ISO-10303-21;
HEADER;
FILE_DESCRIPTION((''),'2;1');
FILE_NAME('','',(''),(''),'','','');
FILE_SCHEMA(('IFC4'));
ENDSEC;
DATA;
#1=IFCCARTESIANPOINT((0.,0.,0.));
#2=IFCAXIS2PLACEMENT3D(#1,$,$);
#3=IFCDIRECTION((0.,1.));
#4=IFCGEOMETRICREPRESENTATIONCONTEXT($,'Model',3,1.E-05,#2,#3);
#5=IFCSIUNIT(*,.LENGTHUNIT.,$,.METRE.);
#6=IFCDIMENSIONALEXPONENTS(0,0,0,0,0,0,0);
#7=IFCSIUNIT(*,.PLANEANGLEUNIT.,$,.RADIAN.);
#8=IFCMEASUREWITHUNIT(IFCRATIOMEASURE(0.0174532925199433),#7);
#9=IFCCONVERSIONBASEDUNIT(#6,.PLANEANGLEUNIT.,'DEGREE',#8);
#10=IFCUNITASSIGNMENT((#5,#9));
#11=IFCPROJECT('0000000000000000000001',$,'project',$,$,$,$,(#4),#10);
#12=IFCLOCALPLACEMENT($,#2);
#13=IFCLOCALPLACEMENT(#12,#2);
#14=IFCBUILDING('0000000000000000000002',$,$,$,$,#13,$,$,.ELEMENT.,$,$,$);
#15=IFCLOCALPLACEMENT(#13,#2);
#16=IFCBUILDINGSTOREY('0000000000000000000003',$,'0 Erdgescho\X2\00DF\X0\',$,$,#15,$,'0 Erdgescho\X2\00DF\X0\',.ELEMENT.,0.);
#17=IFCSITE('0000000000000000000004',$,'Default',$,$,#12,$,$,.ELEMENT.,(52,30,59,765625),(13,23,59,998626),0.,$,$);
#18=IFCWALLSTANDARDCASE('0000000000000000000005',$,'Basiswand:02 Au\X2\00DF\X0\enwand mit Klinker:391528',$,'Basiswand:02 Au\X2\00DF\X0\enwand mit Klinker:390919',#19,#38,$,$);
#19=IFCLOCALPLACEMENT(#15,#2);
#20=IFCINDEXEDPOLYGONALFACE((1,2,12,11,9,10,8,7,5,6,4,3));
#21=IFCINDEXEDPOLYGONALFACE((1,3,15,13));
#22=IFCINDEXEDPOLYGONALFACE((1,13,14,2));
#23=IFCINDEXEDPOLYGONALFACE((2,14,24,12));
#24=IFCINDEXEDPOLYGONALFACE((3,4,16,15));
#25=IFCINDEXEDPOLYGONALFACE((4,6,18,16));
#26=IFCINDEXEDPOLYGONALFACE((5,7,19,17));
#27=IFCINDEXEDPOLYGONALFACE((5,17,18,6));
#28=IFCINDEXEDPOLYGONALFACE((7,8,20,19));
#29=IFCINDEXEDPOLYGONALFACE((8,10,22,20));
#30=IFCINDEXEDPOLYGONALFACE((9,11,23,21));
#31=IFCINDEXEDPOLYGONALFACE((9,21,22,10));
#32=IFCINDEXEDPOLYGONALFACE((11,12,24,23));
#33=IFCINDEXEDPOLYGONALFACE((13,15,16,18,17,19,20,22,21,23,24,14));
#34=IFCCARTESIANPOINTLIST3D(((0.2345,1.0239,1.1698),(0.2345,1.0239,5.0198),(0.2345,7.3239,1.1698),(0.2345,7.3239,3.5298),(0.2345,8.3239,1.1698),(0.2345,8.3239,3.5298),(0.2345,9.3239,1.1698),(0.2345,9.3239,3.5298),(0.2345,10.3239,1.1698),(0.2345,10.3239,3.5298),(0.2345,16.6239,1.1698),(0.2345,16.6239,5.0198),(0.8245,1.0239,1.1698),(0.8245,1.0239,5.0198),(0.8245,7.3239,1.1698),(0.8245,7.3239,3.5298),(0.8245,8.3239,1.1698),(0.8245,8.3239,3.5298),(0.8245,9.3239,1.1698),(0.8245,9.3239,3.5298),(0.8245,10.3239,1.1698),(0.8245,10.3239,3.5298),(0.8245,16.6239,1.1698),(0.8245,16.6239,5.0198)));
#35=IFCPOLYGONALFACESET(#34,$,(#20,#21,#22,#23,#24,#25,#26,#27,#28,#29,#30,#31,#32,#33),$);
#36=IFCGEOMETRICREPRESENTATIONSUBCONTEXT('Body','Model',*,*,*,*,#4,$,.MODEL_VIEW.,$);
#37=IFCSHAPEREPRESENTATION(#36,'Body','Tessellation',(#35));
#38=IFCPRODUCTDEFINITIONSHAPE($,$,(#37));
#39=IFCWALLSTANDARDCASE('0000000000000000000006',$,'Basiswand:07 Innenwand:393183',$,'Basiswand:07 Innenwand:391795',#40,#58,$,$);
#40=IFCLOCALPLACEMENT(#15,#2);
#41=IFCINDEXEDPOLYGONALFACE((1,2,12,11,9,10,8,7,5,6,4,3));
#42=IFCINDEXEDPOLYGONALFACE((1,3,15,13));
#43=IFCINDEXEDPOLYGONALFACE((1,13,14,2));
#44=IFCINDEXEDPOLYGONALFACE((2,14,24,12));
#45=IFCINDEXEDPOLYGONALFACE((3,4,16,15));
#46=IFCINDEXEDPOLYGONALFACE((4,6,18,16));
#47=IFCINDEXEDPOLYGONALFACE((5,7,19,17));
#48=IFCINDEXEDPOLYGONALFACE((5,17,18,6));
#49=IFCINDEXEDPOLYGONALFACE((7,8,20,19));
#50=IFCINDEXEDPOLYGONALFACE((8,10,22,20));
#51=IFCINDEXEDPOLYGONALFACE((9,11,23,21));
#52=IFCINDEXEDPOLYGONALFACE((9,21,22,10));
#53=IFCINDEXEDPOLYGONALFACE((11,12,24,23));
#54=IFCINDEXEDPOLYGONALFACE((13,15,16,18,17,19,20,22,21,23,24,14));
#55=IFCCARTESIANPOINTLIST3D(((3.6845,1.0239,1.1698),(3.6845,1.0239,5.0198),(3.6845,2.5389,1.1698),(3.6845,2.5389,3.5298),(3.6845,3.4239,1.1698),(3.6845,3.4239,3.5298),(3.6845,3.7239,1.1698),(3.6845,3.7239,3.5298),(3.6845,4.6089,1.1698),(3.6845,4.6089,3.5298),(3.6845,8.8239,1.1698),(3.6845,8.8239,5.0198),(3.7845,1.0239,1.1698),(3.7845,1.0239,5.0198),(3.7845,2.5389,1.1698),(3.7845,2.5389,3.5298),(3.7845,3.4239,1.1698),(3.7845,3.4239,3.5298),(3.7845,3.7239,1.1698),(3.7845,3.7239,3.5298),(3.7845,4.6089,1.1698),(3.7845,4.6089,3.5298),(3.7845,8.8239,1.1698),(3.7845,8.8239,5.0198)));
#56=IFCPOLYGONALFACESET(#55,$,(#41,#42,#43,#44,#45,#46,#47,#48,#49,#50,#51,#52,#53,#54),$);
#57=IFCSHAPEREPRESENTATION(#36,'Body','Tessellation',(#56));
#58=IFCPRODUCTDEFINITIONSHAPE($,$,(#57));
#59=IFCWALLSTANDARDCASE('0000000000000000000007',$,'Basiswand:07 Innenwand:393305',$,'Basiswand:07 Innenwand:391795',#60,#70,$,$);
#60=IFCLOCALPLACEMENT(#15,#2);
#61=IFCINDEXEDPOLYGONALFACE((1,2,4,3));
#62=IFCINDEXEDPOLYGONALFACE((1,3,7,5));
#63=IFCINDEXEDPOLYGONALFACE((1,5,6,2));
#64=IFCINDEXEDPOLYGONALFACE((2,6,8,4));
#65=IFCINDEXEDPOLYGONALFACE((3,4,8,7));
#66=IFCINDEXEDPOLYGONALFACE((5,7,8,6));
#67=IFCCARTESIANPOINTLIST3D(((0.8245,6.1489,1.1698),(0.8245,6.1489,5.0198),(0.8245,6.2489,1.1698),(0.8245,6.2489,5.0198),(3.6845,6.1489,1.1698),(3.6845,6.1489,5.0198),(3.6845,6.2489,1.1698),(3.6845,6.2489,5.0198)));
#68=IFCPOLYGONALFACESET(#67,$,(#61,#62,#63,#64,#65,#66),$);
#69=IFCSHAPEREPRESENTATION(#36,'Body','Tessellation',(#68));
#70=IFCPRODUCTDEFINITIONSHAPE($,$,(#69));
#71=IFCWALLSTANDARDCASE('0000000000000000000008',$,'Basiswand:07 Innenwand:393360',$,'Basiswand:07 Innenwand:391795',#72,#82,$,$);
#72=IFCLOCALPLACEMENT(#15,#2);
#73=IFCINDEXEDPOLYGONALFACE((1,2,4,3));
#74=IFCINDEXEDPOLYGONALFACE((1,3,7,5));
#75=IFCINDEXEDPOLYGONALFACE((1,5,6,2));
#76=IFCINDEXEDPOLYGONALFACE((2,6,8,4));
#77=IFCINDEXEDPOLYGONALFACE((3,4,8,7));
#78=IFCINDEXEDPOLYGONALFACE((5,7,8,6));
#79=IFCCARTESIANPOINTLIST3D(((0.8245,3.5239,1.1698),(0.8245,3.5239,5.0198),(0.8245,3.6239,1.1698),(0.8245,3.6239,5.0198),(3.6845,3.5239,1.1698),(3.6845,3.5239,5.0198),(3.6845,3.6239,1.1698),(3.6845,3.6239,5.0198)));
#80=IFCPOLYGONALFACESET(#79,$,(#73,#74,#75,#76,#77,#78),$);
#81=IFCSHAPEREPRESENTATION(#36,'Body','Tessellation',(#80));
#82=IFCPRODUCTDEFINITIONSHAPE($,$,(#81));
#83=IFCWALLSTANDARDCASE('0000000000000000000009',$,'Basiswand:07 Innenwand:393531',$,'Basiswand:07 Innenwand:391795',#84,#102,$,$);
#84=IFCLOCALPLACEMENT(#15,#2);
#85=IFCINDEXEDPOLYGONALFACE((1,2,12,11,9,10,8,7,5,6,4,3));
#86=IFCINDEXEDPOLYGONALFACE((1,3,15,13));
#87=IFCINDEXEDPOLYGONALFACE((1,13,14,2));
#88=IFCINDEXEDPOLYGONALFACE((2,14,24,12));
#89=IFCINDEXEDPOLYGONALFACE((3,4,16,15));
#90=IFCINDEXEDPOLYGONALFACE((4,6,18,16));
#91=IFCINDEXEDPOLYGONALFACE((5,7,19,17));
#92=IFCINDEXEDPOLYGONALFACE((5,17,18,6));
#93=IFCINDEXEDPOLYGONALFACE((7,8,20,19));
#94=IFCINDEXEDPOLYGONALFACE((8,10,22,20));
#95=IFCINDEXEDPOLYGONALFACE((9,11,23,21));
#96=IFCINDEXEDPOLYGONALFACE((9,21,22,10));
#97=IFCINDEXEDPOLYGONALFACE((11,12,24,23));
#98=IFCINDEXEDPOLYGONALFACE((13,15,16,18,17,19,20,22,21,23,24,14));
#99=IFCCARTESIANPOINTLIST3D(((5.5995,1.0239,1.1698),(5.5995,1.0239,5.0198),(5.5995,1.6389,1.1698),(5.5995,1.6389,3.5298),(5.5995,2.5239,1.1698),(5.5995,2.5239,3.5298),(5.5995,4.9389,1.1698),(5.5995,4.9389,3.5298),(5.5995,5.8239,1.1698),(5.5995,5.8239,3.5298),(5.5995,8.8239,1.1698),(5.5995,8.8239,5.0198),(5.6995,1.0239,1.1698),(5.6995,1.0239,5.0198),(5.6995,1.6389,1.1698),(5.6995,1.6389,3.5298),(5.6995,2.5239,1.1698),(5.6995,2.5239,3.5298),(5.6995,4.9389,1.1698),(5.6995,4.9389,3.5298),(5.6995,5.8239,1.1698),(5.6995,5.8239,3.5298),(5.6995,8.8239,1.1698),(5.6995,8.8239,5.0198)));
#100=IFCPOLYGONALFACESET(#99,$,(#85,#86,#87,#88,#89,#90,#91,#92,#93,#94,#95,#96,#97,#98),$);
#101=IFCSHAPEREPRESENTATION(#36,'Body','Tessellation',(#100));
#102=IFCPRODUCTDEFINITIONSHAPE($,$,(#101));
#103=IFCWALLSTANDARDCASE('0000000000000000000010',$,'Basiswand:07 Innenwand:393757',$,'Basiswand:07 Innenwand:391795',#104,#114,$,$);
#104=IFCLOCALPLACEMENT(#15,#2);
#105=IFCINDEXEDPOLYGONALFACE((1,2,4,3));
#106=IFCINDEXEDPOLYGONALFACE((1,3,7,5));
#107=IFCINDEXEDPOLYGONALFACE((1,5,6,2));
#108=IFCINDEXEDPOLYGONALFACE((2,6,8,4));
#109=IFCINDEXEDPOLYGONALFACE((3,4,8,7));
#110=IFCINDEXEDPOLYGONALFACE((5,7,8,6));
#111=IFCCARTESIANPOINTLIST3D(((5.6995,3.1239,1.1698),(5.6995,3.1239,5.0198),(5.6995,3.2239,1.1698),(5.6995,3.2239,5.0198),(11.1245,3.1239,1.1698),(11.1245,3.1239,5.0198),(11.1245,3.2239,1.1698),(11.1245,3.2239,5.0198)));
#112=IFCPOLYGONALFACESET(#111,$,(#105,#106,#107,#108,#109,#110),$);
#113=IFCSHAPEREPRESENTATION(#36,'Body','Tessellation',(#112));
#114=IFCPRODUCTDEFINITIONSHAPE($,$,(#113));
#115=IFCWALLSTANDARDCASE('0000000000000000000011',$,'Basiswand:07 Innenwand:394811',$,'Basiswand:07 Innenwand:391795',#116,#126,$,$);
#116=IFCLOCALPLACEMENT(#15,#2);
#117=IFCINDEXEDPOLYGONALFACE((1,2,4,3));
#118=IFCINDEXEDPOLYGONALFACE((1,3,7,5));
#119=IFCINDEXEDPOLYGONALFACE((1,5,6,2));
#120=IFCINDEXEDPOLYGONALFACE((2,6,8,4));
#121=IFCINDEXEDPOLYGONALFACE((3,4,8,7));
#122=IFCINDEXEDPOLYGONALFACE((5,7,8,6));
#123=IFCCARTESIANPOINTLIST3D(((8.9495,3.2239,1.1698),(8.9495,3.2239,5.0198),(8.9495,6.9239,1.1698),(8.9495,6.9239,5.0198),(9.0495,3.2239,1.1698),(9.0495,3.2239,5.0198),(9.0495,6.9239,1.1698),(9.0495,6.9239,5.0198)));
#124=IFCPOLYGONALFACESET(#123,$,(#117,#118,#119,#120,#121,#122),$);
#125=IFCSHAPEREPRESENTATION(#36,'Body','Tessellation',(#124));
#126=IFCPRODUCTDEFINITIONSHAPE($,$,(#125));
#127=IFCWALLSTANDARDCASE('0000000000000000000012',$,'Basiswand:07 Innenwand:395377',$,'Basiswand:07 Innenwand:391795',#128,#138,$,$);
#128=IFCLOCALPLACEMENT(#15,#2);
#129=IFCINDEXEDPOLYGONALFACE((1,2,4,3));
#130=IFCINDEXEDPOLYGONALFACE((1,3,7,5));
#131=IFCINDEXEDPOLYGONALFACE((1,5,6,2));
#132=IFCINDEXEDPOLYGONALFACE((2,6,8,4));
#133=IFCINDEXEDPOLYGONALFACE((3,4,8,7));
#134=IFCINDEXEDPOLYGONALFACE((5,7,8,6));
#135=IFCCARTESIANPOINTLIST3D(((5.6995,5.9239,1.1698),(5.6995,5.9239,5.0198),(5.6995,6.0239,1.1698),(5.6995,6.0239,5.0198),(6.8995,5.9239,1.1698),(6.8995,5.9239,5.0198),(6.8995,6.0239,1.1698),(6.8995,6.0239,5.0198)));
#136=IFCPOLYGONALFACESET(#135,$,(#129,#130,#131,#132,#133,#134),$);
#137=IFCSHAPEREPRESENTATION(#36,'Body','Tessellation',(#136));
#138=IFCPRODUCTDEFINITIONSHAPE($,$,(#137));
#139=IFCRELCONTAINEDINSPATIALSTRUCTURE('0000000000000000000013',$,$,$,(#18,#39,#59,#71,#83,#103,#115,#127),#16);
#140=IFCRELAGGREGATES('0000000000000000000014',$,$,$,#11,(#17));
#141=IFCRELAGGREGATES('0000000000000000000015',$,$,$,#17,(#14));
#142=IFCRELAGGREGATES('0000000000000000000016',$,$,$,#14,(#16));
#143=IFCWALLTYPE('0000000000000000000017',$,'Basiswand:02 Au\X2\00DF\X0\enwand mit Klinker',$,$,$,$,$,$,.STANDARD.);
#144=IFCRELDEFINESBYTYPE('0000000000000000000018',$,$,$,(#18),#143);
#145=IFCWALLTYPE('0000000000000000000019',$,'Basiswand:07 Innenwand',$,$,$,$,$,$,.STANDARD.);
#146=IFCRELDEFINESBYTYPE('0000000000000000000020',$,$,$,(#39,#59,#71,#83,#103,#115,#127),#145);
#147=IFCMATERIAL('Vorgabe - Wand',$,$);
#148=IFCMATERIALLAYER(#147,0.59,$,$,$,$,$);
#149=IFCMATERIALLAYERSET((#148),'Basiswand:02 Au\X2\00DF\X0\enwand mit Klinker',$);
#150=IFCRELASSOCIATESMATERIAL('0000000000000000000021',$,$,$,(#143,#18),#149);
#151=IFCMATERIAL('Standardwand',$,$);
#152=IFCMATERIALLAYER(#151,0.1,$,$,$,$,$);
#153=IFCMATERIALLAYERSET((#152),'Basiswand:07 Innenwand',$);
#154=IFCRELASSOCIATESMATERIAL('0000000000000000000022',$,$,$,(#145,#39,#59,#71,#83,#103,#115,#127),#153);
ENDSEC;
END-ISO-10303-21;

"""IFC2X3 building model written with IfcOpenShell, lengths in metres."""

from ifc_helpers import new_model, entity, si_unit, converted_unit, direction, frame, frame_2d, origin, place, context, subcontext, project, spatial, polyline, rectangle, extrude, clip, bounded_halfspace, material, layer, layer_set, layer_usage, type_object, element, save


model = new_model("IFC2X3")

# Units and contexts
model_context = context("Model", 3, precision=1e-05, world=origin(), true_north=direction((0.0, 1.0)))
body_context = subcontext(model_context, "Body", "Model", "MODEL_VIEW")
ifc_project = project(units=[si_unit("LENGTHUNIT", "METRE"), converted_unit("PLANEANGLEUNIT", "DEGREE", entity("IfcRatioMeasure", 0.0174532925199433), si_unit("PLANEANGLEUNIT", "RADIAN"), dimensions=[0, 0, 0, 0, 0, 0, 0])], contexts=[model_context])

# Site, building, storey
site_placement = place(None, origin())
site = spatial("IfcSite", under=ifc_project, at=site_placement, Name="Default", CompositionType="ELEMENT", RefLatitude=(52, 30, 59, 765625), RefLongitude=(13, 23, 59, 998626), RefElevation=0.0)
building_placement = place(site_placement, origin())
building = spatial("IfcBuilding", under=site, at=building_placement, CompositionType="ELEMENT")
storey_placement = place(building_placement, origin())
storey = spatial("IfcBuildingStorey", under=building, at=storey_placement, Name="0 Erdgeschoß", LongName="0 Erdgeschoß", CompositionType="ELEMENT", Elevation=0.0)

# Walls, openings
ifc_material_1 = material(Name="Vorgabe - Wand")
ifc_layer_1 = layer(ifc_material_1, 0.59)
ifc_layer_set_1 = layer_set([ifc_layer_1], Name="Basiswand:02 Außenwand mit Klinker")
ifc_layer_usage_1 = layer_usage(ifc_layer_set_1, "AXIS2", "NEGATIVE", 0.295)
wall_type_1 = type_object("IfcWallType", Name="Basiswand:02 Außenwand mit Klinker", PredefinedType="STANDARD", material=ifc_layer_set_1)
wall_1_placement = place(storey_placement, frame((0.5295, 1.0239, 1.1698), z_axis=(0.0, 0.0, 1.0), x_axis=(0.0, 1.0, 0.0)))
wall_1 = element("IfcWallStandardCase", 1, at=wall_1_placement, inside=storey, type_object=wall_type_1, material=ifc_layer_usage_1, Name="Basiswand:02 Außenwand mit Klinker:391528", ObjectType="Basiswand:02 Außenwand mit Klinker:390919", context=body_context, shape_type="Clipping", body=[
    clip(extrude(rectangle(XDim=15.6, YDim=0.59, at=frame_2d((7.8, 0.0), x_axis=(-1.0, 0.0))), origin(), (0.0, 0.0, 1.0), 3.85), bounded_halfspace(frame((0.0, -0.295, 3.85), z_axis=(0.0, 0.0, -1.0), x_axis=(-1.0, 0.0, 0.0)), True, frame((0.0, -0.295, 3.85)), polyline([(0.0, 0.0), (2.5, 0.0), (2.6, 0.0), (5.125, 0.0), (5.225, 0.0), (7.8, 0.0), (7.9, 0.0), (11.9, 0.0), (12.0, 0.0), (13.75, 0.0), (13.85, 0.0), (15.6, 0.0), (15.6, 0.59), (0.0, 0.59), (0.0, 0.0)]))),
])
opening_1_placement = place(wall_1_placement, frame((8.3, -0.295, 0.0)))
element("IfcOpeningElement", 2, at=opening_1_placement, cuts=wall_1, ObjectType="Opening", context=body_context, shape_type="SweptSolid", body=[
    extrude(rectangle(XDim=2.36, YDim=1.0, at=frame_2d((1.18, 0.5), x_axis=(1.0, 0.0))), frame((0.0, 0.0, 0.0), z_axis=(0.0, 1.0, 0.0), x_axis=(0.0, 0.0, 1.0)), (0.0, 0.0, 1.0), 0.59),
])
opening_2_placement = place(wall_1_placement, frame((6.3, -0.295, 0.0)))
element("IfcOpeningElement", 3, at=opening_2_placement, cuts=wall_1, ObjectType="Opening", context=body_context, shape_type="SweptSolid", body=[
    extrude(rectangle(XDim=2.36, YDim=1.0, at=frame_2d((1.18, 0.5), x_axis=(1.0, 0.0))), frame((0.0, 0.0, 0.0), z_axis=(0.0, 1.0, 0.0), x_axis=(0.0, 0.0, 1.0)), (0.0, 0.0, 1.0), 0.59),
])
ifc_material_2 = material(Name="Standardwand")
ifc_layer_2 = layer(ifc_material_2, 0.1)
ifc_layer_set_2 = layer_set([ifc_layer_2], Name="Basiswand:07 Innenwand")
ifc_layer_usage_2 = layer_usage(ifc_layer_set_2, "AXIS2", "NEGATIVE", 0.05)
wall_type_2 = type_object("IfcWallType", Name="Basiswand:07 Innenwand", PredefinedType="STANDARD", material=ifc_layer_set_2)
wall_2_placement = place(storey_placement, frame((3.7345, 1.0239, 1.1698), z_axis=(0.0, 0.0, 1.0), x_axis=(0.0, 1.0, 0.0)))
wall_2 = element("IfcWallStandardCase", 4, at=wall_2_placement, inside=storey, type_object=wall_type_2, material=ifc_layer_usage_2, Name="Basiswand:07 Innenwand:393183", ObjectType="Basiswand:07 Innenwand:391795", context=body_context, shape_type="Clipping", body=[
    clip(extrude(rectangle(XDim=7.8, YDim=0.1, at=frame_2d((3.9, 0.0), x_axis=(-1.0, 0.0))), origin(), (0.0, 0.0, 1.0), 3.85), bounded_halfspace(frame((0.0, -0.05, 3.85), z_axis=(0.0, 0.0, -1.0), x_axis=(-1.0, 0.0, 0.0)), True, frame((0.0, -0.05, 3.85)), polyline([(0.0, 0.0), (7.8, 0.0), (7.8, 0.1), (5.225, 0.1), (5.125, 0.1), (2.6, 0.1), (2.5, 0.1), (0.0, 0.1), (0.0, 0.0)]))),
])
opening_3_placement = place(wall_2_placement, frame((2.7, -0.05, 0.0)))
element("IfcOpeningElement", 5, at=opening_3_placement, cuts=wall_2, ObjectType="Opening", context=body_context, shape_type="SweptSolid", body=[
    extrude(rectangle(XDim=2.36, YDim=0.885, at=frame_2d((1.18, 0.4425), x_axis=(1.0, 0.0))), frame((0.0, 0.0, 0.0), z_axis=(0.0, 1.0, 0.0), x_axis=(0.0, 0.0, 1.0)), (0.0, 0.0, 1.0), 0.1),
])
opening_4_placement = place(wall_2_placement, frame((1.515, -0.05, 0.0)))
element("IfcOpeningElement", 6, at=opening_4_placement, cuts=wall_2, ObjectType="Opening", context=body_context, shape_type="SweptSolid", body=[
    extrude(rectangle(XDim=2.36, YDim=0.885, at=frame_2d((1.18, 0.4425), x_axis=(1.0, 0.0))), frame((0.0, 0.0, 0.0), z_axis=(0.0, 1.0, 0.0), x_axis=(0.0, 0.0, 1.0)), (0.0, 0.0, 1.0), 0.1),
])

# Walls
ifc_layer_usage_3 = layer_usage(ifc_layer_set_2, "AXIS2", "NEGATIVE", 0.05)
wall_3_placement = place(storey_placement, frame((3.6845, 6.1989, 1.1698), z_axis=(0.0, 0.0, 1.0), x_axis=(-1.0, 0.0, 0.0)))
element("IfcWallStandardCase", 7, at=wall_3_placement, inside=storey, type_object=wall_type_2, material=ifc_layer_usage_3, Name="Basiswand:07 Innenwand:393305", ObjectType="Basiswand:07 Innenwand:391795", context=body_context, shape_type="Clipping", body=[
    clip(extrude(rectangle(XDim=2.86, YDim=0.1, at=frame_2d((1.43, 0.0), x_axis=(-1.0, 0.0))), origin(), (0.0, 0.0, 1.0), 3.85), bounded_halfspace(frame((0.0, -0.05, 3.85), z_axis=(0.0, 0.0, -1.0), x_axis=(0.0, 1.0, 0.0)), True, frame((0.0, -0.05, 3.85)), polyline([(0.0, 0.0), (2.86, 0.0), (2.86, 0.1), (0.0, 0.1), (0.0, 0.0)]))),
])
ifc_layer_usage_4 = layer_usage(ifc_layer_set_2, "AXIS2", "NEGATIVE", 0.05)
wall_4_placement = place(storey_placement, frame((3.6845, 3.5739, 1.1698), z_axis=(0.0, 0.0, 1.0), x_axis=(-1.0, 0.0, 0.0)))
element("IfcWallStandardCase", 8, at=wall_4_placement, inside=storey, type_object=wall_type_2, material=ifc_layer_usage_4, Name="Basiswand:07 Innenwand:393360", ObjectType="Basiswand:07 Innenwand:391795", context=body_context, shape_type="Clipping", body=[
    clip(extrude(rectangle(XDim=2.86, YDim=0.1, at=frame_2d((1.43, 0.0), x_axis=(-1.0, 0.0))), origin(), (0.0, 0.0, 1.0), 3.85), bounded_halfspace(frame((0.0, -0.05, 3.85), z_axis=(0.0, 0.0, -1.0), x_axis=(0.0, 1.0, 0.0)), True, frame((0.0, -0.05, 3.85)), polyline([(0.0, 0.0), (2.86, 0.0), (2.86, 0.1), (0.0, 0.1), (0.0, 0.0)]))),
])

# Wall, openings
ifc_layer_usage_5 = layer_usage(ifc_layer_set_2, "AXIS2", "NEGATIVE", 0.05)
wall_5_placement = place(storey_placement, frame((5.6495, 1.0239, 1.1698), z_axis=(0.0, 0.0, 1.0), x_axis=(0.0, 1.0, 0.0)))
wall_5 = element("IfcWallStandardCase", 9, at=wall_5_placement, inside=storey, type_object=wall_type_2, material=ifc_layer_usage_5, Name="Basiswand:07 Innenwand:393531", ObjectType="Basiswand:07 Innenwand:391795", context=body_context, shape_type="Clipping", body=[
    clip(extrude(rectangle(XDim=7.8, YDim=0.1, at=frame_2d((3.9, 0.0), x_axis=(-1.0, 0.0))), origin(), (0.0, 0.0, 1.0), 3.85), bounded_halfspace(frame((0.0, -0.05, 3.85), z_axis=(0.0, 0.0, -1.0), x_axis=(-1.0, 0.0, 0.0)), True, frame((0.0, -0.05, 3.85)), polyline([(0.0, 0.0), (2.1, 0.0), (2.2, 0.0), (3.1, 0.0), (3.2, 0.0), (4.9, 0.0), (5.0, 0.0), (5.9, 0.0), (6.0, 0.0), (7.8, 0.0), (7.8, 0.1), (0.0, 0.1), (0.0, 0.0)]))),
])
opening_5_placement = place(wall_5_placement, frame((1.5, 0.05, 0.0)))
element("IfcOpeningElement", 10, at=opening_5_placement, cuts=wall_5, ObjectType="Opening", context=body_context, shape_type="SweptSolid", body=[
    extrude(rectangle(XDim=2.36, YDim=0.885, at=frame_2d((1.18, 0.4425), x_axis=(1.0, 0.0))), frame((0.0, 0.0, 0.0), z_axis=(0.0, -1.0, 0.0), x_axis=(0.0, 0.0, 1.0)), (0.0, 0.0, 1.0), 0.1),
])
opening_6_placement = place(wall_5_placement, frame((4.8, 0.05, 0.0)))
element("IfcOpeningElement", 11, at=opening_6_placement, cuts=wall_5, ObjectType="Opening", context=body_context, shape_type="SweptSolid", body=[
    extrude(rectangle(XDim=2.36, YDim=0.885, at=frame_2d((1.18, 0.4425), x_axis=(1.0, 0.0))), frame((0.0, 0.0, 0.0), z_axis=(0.0, -1.0, 0.0), x_axis=(0.0, 0.0, 1.0)), (0.0, 0.0, 1.0), 0.1),
])

# Walls
ifc_layer_usage_6 = layer_usage(ifc_layer_set_2, "AXIS2", "POSITIVE", -0.05)
wall_6_placement = place(storey_placement, frame((5.6995, 3.1739, 1.1698), z_axis=(0.0, 0.0, 1.0), x_axis=(1.0, 0.0, 0.0)))
element("IfcWallStandardCase", 12, at=wall_6_placement, inside=storey, type_object=wall_type_2, material=ifc_layer_usage_6, Name="Basiswand:07 Innenwand:393757", ObjectType="Basiswand:07 Innenwand:391795", context=body_context, shape_type="Clipping", body=[
    clip(extrude(rectangle(XDim=5.425, YDim=0.1, at=frame_2d((2.7125, 0.0), x_axis=(-1.0, 0.0))), origin(), (0.0, 0.0, 1.0), 3.85), bounded_halfspace(frame((0.0, -0.05, 3.85), z_axis=(0.0, 0.0, -1.0), x_axis=(0.0, -1.0, 0.0)), True, frame((0.0, -0.05, 3.85)), polyline([(0.0, 0.0), (2.25, 0.0), (2.35, 0.0), (5.425, 0.0), (5.425, 0.1), (3.35, 0.1), (3.25, 0.1), (0.0, 0.1), (0.0, 0.0)]))),
])
ifc_layer_usage_7 = layer_usage(ifc_layer_set_2, "AXIS2", "NEGATIVE", 0.05)
wall_7_placement = place(storey_placement, frame((8.9995, 3.2239, 1.1698), z_axis=(0.0, 0.0, 1.0), x_axis=(0.0, 1.0, 0.0)))
element("IfcWallStandardCase", 13, at=wall_7_placement, inside=storey, type_object=wall_type_2, material=ifc_layer_usage_7, Name="Basiswand:07 Innenwand:394811", ObjectType="Basiswand:07 Innenwand:391795", context=body_context, shape_type="Clipping", body=[
    clip(extrude(rectangle(XDim=3.7, YDim=0.1, at=frame_2d((1.85, 0.0), x_axis=(-1.0, 0.0))), origin(), (0.0, 0.0, 1.0), 3.85), bounded_halfspace(frame((0.0, -0.05, 3.85), z_axis=(0.0, 0.0, -1.0), x_axis=(-1.0, 0.0, 0.0)), True, frame((0.0, -0.05, 3.85)), polyline([(0.0, 0.0), (3.7, 0.0), (3.7, 0.1), (1.9, 0.1), (1.8, 0.1), (0.0, 0.1), (0.0, 0.0)]))),
])
ifc_layer_usage_8 = layer_usage(ifc_layer_set_2, "AXIS2", "POSITIVE", -0.05)
wall_8_placement = place(storey_placement, frame((5.6995, 5.9739, 1.1698), z_axis=(0.0, 0.0, 1.0), x_axis=(1.0, 0.0, 0.0)))
element("IfcWallStandardCase", 14, at=wall_8_placement, inside=storey, type_object=wall_type_2, material=ifc_layer_usage_8, Name="Basiswand:07 Innenwand:395377", ObjectType="Basiswand:07 Innenwand:391795", context=body_context, shape_type="Clipping", body=[
    clip(extrude(rectangle(XDim=1.2, YDim=0.1, at=frame_2d((0.6, 0.0), x_axis=(-1.0, 0.0))), origin(), (0.0, 0.0, 1.0), 3.85), bounded_halfspace(frame((0.0, -0.05, 3.85), z_axis=(0.0, 0.0, -1.0), x_axis=(0.0, -1.0, 0.0)), True, frame((0.0, -0.05, 3.85)), polyline([(0.0, 0.0), (1.1, 0.0), (1.2, 0.0), (1.2, 0.1), (0.0, 0.1), (0.0, 0.0)]))),
])

save(model, "model.ifc")
